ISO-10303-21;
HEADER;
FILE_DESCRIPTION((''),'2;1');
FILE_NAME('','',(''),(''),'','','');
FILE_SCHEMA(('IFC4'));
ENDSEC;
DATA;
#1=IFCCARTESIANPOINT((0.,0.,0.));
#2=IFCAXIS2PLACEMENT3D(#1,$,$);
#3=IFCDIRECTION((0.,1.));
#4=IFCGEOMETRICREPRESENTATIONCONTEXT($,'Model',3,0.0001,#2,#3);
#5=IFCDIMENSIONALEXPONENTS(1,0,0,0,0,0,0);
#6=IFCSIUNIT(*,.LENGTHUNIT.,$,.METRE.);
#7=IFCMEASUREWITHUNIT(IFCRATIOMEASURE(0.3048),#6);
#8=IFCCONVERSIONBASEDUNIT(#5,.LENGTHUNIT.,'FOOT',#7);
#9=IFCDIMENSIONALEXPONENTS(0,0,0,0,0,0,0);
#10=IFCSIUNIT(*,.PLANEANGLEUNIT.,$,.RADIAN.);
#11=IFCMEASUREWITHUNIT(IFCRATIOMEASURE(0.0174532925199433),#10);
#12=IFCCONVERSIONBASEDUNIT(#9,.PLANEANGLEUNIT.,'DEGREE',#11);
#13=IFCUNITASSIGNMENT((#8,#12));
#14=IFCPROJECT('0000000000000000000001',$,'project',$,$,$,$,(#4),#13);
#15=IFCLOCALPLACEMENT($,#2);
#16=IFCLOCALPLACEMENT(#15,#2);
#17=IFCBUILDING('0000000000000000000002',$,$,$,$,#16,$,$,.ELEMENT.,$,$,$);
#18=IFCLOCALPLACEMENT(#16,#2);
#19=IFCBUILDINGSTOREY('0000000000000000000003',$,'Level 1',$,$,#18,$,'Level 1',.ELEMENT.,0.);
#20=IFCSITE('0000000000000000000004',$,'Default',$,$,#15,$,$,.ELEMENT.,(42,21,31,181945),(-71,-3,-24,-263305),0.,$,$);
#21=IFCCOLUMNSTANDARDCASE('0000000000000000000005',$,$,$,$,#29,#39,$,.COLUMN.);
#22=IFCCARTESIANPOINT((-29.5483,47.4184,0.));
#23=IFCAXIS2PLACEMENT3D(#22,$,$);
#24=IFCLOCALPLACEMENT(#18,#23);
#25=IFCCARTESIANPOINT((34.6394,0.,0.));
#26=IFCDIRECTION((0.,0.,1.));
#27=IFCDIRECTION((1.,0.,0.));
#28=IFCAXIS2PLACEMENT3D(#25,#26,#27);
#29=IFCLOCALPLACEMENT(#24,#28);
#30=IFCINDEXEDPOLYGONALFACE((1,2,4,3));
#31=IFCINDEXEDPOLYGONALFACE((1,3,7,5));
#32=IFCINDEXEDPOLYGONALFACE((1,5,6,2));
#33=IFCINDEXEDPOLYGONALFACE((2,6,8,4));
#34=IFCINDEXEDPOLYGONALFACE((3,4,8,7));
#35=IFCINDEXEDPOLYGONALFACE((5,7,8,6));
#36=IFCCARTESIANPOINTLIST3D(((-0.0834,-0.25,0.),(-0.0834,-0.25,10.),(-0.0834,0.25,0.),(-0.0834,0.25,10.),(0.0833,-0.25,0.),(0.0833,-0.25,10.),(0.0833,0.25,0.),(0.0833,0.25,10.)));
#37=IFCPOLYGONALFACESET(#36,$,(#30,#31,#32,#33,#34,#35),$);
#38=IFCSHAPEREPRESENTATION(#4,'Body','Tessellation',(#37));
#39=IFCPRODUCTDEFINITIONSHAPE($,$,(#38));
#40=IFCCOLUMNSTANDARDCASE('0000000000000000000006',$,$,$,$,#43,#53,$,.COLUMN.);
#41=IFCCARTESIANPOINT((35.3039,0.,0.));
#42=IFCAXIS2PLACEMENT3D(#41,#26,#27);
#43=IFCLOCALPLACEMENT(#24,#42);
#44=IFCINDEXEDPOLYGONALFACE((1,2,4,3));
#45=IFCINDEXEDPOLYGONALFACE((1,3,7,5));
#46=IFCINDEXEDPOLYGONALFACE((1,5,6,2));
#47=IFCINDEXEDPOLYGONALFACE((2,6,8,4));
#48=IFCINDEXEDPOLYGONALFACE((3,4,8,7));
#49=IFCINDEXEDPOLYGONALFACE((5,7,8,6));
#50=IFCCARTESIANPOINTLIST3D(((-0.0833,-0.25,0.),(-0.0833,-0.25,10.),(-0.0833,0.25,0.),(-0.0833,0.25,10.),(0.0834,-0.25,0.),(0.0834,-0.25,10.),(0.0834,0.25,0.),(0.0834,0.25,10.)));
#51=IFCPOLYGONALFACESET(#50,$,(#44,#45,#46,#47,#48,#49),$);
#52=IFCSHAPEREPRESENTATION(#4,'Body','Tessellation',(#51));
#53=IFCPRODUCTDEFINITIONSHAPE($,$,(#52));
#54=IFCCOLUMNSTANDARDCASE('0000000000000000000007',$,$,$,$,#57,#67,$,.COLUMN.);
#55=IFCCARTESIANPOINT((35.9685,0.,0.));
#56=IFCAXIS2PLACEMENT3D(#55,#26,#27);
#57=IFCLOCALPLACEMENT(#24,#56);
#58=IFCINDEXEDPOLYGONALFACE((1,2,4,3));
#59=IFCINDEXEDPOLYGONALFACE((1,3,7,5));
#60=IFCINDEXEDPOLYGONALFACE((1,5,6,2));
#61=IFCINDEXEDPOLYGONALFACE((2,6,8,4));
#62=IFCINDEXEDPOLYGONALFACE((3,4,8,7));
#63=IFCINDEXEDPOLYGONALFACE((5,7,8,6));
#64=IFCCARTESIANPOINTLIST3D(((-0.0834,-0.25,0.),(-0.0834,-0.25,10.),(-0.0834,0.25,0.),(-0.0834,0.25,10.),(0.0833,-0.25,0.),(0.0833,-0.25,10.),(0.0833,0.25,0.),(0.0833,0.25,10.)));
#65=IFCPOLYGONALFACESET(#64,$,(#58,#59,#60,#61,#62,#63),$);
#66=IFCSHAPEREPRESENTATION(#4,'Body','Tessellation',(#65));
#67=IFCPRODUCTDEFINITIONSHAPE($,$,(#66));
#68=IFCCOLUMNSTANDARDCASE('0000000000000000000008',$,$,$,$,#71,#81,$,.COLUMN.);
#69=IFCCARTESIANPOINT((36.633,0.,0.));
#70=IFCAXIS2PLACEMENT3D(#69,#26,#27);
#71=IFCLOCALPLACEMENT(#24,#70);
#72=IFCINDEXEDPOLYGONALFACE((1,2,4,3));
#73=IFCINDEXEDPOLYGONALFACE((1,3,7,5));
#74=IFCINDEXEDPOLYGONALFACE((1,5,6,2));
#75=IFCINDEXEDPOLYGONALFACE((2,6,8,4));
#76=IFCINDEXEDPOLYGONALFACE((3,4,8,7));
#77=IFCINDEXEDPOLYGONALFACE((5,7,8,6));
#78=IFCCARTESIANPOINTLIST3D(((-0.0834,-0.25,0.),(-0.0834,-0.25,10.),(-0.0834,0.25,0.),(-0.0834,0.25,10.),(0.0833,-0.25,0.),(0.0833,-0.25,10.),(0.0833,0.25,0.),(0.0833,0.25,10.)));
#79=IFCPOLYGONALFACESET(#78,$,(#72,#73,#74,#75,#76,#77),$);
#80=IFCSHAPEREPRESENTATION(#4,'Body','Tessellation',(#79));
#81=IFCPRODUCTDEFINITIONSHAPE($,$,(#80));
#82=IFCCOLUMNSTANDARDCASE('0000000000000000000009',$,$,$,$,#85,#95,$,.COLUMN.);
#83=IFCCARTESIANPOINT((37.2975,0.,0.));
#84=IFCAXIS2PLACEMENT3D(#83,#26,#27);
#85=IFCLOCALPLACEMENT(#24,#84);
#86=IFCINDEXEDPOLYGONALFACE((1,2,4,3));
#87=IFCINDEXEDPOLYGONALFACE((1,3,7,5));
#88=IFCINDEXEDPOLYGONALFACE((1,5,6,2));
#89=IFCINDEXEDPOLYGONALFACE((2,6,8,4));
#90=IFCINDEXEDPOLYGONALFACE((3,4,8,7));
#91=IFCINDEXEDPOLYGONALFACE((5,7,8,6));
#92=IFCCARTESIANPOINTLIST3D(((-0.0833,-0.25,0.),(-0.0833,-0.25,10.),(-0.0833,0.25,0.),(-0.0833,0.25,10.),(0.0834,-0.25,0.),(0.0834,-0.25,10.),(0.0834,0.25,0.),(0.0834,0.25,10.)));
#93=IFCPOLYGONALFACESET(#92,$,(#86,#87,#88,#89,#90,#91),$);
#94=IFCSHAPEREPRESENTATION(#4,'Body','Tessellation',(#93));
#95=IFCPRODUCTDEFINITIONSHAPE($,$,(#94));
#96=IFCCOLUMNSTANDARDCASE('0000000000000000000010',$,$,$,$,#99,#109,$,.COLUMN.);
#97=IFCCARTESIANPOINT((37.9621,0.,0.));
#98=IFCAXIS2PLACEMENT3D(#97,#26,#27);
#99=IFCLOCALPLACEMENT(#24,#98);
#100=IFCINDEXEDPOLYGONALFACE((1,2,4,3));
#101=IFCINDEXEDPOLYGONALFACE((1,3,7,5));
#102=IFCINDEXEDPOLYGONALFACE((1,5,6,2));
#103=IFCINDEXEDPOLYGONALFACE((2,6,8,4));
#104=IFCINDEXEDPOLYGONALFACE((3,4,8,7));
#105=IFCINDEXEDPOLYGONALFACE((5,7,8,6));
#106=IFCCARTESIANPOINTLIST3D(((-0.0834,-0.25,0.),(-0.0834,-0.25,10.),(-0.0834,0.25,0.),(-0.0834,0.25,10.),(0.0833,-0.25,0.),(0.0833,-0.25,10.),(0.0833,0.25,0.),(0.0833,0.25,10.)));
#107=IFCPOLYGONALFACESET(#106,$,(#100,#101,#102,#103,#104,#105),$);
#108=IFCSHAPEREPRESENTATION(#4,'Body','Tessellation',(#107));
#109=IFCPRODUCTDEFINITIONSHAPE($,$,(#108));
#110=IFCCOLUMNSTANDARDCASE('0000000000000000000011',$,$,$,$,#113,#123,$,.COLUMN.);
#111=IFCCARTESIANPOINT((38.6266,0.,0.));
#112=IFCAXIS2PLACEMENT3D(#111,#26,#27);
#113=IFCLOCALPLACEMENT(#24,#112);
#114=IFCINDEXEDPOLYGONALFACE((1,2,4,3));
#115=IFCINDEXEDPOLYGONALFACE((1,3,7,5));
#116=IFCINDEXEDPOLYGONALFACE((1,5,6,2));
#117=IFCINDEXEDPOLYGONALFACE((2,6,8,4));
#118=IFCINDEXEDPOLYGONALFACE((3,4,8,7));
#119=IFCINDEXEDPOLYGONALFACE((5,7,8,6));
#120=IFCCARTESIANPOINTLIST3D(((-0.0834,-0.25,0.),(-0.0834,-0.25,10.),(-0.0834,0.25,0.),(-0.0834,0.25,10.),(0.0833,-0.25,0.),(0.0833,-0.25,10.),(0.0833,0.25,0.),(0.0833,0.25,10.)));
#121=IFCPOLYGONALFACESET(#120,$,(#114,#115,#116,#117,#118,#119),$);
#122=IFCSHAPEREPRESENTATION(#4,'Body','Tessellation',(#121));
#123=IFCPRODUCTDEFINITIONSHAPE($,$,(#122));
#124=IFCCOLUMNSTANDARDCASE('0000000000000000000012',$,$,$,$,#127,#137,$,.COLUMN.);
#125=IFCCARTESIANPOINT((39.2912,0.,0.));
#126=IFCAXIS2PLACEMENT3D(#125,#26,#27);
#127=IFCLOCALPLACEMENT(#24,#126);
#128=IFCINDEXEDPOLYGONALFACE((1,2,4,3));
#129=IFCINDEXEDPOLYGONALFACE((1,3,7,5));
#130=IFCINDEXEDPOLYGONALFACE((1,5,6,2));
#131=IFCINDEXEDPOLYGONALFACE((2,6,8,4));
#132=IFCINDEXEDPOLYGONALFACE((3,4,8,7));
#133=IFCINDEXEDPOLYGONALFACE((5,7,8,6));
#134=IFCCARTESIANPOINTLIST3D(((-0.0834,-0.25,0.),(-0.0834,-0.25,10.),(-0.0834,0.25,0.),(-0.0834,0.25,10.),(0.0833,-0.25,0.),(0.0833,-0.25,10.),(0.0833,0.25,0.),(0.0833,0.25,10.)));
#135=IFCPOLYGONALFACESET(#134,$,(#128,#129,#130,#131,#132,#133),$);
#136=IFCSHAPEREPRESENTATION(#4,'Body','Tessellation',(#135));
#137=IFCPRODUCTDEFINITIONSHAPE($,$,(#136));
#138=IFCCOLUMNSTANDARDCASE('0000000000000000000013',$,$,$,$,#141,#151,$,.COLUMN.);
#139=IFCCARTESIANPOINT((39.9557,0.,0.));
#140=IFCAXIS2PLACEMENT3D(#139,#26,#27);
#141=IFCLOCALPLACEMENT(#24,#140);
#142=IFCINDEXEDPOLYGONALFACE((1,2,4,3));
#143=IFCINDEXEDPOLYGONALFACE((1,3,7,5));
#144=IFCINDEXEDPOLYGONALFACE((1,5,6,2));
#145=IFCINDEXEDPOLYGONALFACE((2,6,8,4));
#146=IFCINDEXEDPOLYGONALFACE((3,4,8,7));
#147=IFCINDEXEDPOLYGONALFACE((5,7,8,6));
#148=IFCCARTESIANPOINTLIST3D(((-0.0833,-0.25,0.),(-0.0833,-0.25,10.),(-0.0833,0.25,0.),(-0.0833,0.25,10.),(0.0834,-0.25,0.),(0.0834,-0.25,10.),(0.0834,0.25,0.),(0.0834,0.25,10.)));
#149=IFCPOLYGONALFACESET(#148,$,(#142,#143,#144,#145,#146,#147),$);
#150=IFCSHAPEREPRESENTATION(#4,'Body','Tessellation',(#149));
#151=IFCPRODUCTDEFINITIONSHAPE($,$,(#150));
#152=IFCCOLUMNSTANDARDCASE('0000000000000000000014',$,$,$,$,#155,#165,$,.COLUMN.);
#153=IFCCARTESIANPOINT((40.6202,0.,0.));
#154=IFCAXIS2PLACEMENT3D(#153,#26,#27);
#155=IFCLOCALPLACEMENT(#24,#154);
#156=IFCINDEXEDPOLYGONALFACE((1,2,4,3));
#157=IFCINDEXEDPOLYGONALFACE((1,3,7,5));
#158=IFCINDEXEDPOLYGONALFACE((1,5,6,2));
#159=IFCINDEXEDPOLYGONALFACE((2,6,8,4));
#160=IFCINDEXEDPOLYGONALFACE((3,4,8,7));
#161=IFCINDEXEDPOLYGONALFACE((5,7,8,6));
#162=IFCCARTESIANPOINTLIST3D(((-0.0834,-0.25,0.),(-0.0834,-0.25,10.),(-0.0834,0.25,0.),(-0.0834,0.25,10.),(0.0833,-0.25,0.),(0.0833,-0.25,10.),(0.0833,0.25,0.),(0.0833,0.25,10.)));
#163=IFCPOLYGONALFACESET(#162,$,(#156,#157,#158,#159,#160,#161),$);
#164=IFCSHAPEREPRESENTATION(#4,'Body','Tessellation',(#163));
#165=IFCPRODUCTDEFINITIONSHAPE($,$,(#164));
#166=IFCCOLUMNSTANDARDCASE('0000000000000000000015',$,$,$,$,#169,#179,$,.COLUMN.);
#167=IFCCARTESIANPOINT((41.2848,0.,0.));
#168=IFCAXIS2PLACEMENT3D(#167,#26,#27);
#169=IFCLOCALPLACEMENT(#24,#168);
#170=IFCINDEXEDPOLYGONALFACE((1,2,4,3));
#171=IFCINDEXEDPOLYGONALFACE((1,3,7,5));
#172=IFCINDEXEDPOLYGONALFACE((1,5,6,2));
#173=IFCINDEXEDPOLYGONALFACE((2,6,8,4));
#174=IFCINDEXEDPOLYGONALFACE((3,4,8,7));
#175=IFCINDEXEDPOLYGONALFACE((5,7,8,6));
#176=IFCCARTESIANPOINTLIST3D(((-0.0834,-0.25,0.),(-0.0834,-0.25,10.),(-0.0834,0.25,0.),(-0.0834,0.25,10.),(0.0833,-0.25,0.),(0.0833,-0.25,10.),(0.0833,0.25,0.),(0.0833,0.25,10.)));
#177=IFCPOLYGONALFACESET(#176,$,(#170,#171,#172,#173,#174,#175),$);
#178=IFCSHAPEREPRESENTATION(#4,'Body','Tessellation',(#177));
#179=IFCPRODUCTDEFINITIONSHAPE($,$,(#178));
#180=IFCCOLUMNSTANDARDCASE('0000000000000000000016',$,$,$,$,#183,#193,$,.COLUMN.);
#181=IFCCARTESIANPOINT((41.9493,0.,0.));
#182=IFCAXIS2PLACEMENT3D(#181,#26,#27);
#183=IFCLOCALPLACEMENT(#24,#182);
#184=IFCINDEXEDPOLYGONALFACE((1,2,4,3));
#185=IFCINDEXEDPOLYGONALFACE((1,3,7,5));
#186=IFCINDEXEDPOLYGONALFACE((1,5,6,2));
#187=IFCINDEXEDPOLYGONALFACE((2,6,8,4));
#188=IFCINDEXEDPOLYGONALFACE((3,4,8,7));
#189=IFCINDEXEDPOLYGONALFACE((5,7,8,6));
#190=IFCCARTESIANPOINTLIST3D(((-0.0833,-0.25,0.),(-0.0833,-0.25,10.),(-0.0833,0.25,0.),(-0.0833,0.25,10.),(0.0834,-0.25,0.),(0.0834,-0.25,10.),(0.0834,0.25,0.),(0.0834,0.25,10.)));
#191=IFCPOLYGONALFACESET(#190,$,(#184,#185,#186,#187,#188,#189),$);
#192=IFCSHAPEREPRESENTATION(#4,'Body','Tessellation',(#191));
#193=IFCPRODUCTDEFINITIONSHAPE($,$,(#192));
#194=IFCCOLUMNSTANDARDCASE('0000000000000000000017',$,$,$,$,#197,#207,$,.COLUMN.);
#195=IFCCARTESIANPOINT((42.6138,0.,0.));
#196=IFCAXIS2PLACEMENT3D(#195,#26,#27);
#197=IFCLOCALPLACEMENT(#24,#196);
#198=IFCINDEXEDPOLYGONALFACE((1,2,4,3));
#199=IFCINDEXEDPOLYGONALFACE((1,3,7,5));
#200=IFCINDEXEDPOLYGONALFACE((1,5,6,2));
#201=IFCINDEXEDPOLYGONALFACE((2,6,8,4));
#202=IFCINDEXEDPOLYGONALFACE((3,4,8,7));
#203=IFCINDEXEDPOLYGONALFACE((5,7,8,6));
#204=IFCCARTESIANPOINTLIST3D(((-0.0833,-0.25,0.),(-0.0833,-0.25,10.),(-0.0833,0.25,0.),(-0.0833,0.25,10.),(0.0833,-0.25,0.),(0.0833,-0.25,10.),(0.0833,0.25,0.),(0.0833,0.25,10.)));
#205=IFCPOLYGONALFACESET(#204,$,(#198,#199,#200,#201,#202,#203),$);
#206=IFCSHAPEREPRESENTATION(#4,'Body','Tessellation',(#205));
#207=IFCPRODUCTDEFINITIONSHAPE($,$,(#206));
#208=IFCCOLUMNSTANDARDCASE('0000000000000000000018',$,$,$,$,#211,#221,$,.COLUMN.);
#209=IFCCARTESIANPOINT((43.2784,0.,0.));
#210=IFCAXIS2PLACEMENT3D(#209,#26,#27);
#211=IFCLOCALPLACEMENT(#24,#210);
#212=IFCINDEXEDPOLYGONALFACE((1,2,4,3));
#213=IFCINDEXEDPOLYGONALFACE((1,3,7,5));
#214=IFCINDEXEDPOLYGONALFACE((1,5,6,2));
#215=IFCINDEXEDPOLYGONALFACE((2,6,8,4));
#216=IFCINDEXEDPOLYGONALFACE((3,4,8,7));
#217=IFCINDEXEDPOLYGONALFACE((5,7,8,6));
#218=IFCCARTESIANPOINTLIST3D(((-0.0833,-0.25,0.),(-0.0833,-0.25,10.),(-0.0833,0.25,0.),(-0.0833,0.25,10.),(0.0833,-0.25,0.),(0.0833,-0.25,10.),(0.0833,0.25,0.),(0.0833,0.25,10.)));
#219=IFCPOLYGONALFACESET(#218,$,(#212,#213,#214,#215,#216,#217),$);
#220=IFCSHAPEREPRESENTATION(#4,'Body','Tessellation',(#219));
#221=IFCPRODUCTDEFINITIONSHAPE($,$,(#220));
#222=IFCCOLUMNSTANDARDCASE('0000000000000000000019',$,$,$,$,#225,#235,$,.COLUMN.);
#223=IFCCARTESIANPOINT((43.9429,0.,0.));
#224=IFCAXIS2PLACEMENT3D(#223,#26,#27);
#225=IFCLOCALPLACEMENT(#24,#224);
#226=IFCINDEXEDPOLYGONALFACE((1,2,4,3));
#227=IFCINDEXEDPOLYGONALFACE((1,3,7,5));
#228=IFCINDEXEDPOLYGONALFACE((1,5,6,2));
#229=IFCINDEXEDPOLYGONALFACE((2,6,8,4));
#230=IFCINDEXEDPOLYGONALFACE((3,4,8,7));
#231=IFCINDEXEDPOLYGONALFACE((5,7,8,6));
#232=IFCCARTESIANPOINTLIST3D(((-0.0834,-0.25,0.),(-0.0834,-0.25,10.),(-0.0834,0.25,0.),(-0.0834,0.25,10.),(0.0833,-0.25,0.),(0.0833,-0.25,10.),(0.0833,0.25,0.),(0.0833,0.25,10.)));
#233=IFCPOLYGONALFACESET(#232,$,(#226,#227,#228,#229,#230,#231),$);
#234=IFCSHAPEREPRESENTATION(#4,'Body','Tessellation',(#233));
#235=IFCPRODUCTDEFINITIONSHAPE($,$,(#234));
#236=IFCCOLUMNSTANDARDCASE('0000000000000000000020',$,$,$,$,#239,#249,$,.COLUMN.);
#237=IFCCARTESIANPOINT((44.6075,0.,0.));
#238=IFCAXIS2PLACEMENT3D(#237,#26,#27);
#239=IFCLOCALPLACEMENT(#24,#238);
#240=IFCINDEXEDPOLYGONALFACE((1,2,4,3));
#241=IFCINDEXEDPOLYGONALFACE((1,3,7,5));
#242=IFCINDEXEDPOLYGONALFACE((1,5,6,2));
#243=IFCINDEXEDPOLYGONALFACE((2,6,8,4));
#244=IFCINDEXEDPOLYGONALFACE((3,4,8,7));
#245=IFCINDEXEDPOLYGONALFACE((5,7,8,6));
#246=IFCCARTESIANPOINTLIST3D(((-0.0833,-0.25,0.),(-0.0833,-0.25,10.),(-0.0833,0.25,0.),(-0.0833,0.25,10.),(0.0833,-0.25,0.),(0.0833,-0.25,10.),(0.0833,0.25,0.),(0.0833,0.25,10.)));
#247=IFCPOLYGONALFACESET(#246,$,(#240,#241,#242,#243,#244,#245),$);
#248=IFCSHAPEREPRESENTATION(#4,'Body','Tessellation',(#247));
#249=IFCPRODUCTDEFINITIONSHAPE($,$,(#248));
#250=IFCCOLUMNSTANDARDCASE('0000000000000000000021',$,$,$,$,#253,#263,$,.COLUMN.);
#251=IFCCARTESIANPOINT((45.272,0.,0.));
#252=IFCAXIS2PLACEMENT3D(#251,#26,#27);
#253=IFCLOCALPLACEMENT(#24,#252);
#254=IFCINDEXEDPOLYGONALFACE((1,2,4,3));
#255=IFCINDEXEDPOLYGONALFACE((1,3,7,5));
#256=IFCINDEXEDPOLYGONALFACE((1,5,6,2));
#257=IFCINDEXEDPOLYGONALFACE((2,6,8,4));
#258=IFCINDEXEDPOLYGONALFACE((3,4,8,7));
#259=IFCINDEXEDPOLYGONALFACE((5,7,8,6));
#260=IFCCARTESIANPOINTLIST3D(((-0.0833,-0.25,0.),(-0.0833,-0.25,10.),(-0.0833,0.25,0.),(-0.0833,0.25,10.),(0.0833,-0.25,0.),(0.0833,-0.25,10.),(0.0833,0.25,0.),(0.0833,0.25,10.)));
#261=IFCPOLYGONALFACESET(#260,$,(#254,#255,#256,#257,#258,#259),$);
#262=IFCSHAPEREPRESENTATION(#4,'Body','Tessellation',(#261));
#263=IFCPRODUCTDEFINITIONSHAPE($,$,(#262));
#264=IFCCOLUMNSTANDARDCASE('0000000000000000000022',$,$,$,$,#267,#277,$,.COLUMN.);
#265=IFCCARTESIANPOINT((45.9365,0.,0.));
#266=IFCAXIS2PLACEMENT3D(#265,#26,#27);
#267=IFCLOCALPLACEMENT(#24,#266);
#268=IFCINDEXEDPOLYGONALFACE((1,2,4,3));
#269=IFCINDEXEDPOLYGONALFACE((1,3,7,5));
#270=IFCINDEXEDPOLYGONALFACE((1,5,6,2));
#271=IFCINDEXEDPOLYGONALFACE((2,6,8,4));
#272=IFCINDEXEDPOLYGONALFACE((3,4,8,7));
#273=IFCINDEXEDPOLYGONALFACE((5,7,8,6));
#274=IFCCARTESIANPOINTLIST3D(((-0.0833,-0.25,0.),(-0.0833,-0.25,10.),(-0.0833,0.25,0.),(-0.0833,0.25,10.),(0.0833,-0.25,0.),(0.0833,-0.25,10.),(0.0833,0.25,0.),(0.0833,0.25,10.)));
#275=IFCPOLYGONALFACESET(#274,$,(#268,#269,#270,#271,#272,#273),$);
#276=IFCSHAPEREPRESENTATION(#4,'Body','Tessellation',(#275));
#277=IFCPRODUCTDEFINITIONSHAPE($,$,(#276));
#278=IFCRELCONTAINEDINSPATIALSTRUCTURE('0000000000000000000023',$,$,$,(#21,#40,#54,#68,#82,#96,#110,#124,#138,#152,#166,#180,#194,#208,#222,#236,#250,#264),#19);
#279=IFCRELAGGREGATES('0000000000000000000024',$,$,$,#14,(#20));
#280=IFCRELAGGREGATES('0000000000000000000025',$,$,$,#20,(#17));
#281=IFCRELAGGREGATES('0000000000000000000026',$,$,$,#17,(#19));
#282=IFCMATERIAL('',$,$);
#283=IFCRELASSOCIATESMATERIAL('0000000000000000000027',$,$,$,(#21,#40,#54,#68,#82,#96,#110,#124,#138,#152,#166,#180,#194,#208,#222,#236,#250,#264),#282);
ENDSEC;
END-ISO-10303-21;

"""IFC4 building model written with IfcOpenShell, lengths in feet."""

from ifc_helpers import new_model, entity, si_unit, converted_unit, direction, frame, origin, place, context, project, spatial, rectangle, extrude, material, element, save


model = new_model("IFC4")

# Units and contexts
model_context = context("Model", 3, precision=0.0001, world=origin(), true_north=direction((0.0, 1.0)))
ifc_project = project(units=[converted_unit("LENGTHUNIT", "FOOT", entity("IfcRatioMeasure", 0.3048), si_unit("LENGTHUNIT", "METRE"), dimensions=[1, 0, 0, 0, 0, 0, 0]), converted_unit("PLANEANGLEUNIT", "DEGREE", entity("IfcRatioMeasure", 0.0174532925199433), si_unit("PLANEANGLEUNIT", "RADIAN"), dimensions=[0, 0, 0, 0, 0, 0, 0])], contexts=[model_context])

# Site, building, storey
site_placement = place(None, origin())
site = spatial("IfcSite", under=ifc_project, at=site_placement, Name="Default", CompositionType="ELEMENT", RefLatitude=(42, 21, 31, 181945), RefLongitude=(-71, -3, -24, -263305), RefElevation=0.0)
building_placement = place(site_placement, origin())
building = spatial("IfcBuilding", under=site, at=building_placement, CompositionType="ELEMENT")
storey_placement = place(building_placement, origin())
storey = spatial("IfcBuildingStorey", under=building, at=storey_placement, Name="Level 1", LongName="Level 1", CompositionType="ELEMENT", Elevation=0.0)

# Columns
ifc_material_1 = material(Name="")
placement = place(storey_placement, frame((-29.5483, 47.4184, 0.0)))
for number, where, z_axis, x_axis in (
    (1, (34.6394, 0.0, 0.0), (0.0, 0.0, 1.0), (1.0, 0.0, 0.0)),
    (2, (35.3039, 0.0, 0.0), (0.0, 0.0, 1.0), (1.0, 0.0, 0.0)),
    (3, (35.9685, 0.0, 0.0), (0.0, 0.0, 1.0), (1.0, 0.0, 0.0)),
    (4, (36.633, 0.0, 0.0), (0.0, 0.0, 1.0), (1.0, 0.0, 0.0)),
    (5, (37.2975, 0.0, 0.0), (0.0, 0.0, 1.0), (1.0, 0.0, 0.0)),
    (6, (37.9621, 0.0, 0.0), (0.0, 0.0, 1.0), (1.0, 0.0, 0.0)),
    (7, (38.6266, 0.0, 0.0), (0.0, 0.0, 1.0), (1.0, 0.0, 0.0)),
    (8, (39.2912, 0.0, 0.0), (0.0, 0.0, 1.0), (1.0, 0.0, 0.0)),
    (9, (39.9557, 0.0, 0.0), (0.0, 0.0, 1.0), (1.0, 0.0, 0.0)),
    (10, (40.6202, 0.0, 0.0), (0.0, 0.0, 1.0), (1.0, 0.0, 0.0)),
    (11, (41.2848, 0.0, 0.0), (0.0, 0.0, 1.0), (1.0, 0.0, 0.0)),
    (12, (41.9493, 0.0, 0.0), (0.0, 0.0, 1.0), (1.0, 0.0, 0.0)),
    (13, (42.6138, 0.0, 0.0), (0.0, 0.0, 1.0), (1.0, 0.0, 0.0)),
    (14, (43.2784, 0.0, 0.0), (0.0, 0.0, 1.0), (1.0, 0.0, 0.0)),
    (15, (43.9429, 0.0, 0.0), (0.0, 0.0, 1.0), (1.0, 0.0, 0.0)),
    (16, (44.6075, 0.0, 0.0), (0.0, 0.0, 1.0), (1.0, 0.0, 0.0)),
    (17, (45.272, 0.0, 0.0), (0.0, 0.0, 1.0), (1.0, 0.0, 0.0)),
    (18, (45.9365, 0.0, 0.0), (0.0, 0.0, 1.0), (1.0, 0.0, 0.0)),
):
    element("IfcColumnStandardCase", number, at=place(placement, frame(where, z_axis=z_axis, x_axis=x_axis)), inside=storey, material=ifc_material_1, PredefinedType="COLUMN", context=model_context, shape_type="SweptSolid", body=[
        extrude(rectangle(XDim=0.1667, YDim=0.5), origin(), (0.0, 0.0, 1.0), 10.0),
    ])

save(model, "model.ifc")
